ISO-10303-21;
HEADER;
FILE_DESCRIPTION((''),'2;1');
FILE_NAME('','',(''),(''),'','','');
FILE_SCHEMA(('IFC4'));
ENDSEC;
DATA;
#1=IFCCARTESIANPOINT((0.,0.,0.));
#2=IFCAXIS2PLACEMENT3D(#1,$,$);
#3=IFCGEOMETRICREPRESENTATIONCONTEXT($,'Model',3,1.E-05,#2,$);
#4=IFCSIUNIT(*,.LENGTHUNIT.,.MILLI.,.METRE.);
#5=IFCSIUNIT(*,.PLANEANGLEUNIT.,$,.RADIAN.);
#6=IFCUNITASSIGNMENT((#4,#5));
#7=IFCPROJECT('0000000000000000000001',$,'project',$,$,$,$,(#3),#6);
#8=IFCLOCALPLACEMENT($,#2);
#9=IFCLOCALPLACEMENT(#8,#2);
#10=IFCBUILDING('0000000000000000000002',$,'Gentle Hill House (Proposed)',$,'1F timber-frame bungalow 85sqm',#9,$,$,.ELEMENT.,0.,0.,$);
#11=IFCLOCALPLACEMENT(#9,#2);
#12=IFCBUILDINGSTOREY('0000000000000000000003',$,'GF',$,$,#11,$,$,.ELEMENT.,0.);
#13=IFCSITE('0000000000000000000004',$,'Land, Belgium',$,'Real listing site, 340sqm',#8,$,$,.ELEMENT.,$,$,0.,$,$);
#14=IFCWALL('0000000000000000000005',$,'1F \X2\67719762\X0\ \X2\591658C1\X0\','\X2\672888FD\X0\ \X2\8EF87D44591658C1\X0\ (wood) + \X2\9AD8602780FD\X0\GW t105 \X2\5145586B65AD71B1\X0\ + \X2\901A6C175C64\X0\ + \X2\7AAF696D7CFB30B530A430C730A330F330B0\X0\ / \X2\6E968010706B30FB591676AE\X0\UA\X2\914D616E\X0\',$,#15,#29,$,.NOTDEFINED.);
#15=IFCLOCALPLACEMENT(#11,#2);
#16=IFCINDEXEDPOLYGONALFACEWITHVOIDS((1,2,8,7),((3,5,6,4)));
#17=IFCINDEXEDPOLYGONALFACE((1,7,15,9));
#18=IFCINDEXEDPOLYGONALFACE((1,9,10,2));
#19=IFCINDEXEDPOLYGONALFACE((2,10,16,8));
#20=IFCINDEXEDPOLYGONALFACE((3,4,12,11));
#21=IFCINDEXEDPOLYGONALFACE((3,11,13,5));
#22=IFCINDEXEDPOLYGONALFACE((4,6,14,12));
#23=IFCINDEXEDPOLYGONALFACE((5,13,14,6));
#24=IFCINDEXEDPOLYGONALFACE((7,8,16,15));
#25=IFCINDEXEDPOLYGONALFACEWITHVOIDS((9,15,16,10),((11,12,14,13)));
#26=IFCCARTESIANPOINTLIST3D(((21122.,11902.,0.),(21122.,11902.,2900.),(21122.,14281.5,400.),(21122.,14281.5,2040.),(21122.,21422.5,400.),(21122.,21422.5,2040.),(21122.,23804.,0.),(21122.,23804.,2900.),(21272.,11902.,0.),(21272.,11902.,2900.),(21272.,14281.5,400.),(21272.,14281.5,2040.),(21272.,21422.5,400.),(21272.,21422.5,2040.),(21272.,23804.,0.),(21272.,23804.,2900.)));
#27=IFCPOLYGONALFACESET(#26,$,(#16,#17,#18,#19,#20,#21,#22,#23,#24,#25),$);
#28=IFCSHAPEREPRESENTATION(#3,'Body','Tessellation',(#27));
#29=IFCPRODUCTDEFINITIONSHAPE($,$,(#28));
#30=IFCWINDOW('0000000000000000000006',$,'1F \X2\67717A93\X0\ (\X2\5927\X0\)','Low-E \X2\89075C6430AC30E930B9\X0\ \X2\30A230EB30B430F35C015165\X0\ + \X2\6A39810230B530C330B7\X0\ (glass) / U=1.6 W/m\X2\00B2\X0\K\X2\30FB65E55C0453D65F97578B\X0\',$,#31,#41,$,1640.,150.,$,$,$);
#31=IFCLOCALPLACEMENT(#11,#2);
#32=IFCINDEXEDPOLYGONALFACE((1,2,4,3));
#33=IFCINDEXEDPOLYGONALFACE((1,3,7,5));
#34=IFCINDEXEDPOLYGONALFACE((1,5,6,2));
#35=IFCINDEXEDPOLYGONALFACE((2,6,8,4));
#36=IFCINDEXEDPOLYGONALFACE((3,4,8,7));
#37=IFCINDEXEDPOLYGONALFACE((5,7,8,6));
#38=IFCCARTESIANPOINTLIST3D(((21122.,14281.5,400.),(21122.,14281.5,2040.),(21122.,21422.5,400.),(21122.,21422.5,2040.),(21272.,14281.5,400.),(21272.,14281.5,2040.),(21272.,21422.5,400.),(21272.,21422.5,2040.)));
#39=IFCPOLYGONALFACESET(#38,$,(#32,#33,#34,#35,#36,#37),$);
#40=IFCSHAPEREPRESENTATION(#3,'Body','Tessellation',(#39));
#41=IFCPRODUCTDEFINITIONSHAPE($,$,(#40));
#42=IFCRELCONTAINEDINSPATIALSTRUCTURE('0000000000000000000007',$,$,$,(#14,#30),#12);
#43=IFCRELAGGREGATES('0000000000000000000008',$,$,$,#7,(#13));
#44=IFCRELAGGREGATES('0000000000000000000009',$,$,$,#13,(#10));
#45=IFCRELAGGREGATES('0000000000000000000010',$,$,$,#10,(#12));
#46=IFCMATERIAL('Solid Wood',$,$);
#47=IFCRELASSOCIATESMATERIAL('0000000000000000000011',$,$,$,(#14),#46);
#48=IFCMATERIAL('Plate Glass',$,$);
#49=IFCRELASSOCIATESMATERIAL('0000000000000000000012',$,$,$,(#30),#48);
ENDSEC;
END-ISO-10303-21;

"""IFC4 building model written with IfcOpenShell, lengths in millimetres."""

from ifc_helpers import new_model, si_unit, frame, frame_2d, origin, place, context, project, spatial, rectangle, extrude, material, element, fill, save


model = new_model("IFC4")

# Units and contexts
model_context = context("Model", 3, precision=1e-05, world=origin())
ifc_project = project(units=[si_unit("LENGTHUNIT", "METRE", prefix="MILLI"), si_unit("PLANEANGLEUNIT", "RADIAN")], contexts=[model_context])

# Site, building, storey
site_placement = place(None, origin())
site = spatial("IfcSite", under=ifc_project, at=site_placement, Name="Land, Belgium", ObjectType="Real listing site, 340sqm", CompositionType="ELEMENT", RefElevation=0.0)
building_placement = place(site_placement, origin())
building = spatial("IfcBuilding", under=site, at=building_placement, Name="Gentle Hill House (Proposed)", ObjectType="1F timber-frame bungalow 85sqm", CompositionType="ELEMENT", ElevationOfRefHeight=0.0, ElevationOfTerrain=0.0)
storey_placement = place(building_placement, origin())
storey = spatial("IfcBuildingStorey", under=building, at=storey_placement, Name="GF", CompositionType="ELEMENT", Elevation=0.0)

# Shared definitions
ifc_material_1 = material(Name="Solid Wood")

# Shared definitions
ifc_material_2 = material(Name="Plate Glass")

# Wall, opening, window
wall_1_placement = place(storey_placement, frame((10561.0, 5951.0, 0.0)))
wall_1 = element("IfcWall", 1, at=wall_1_placement, inside=storey, material=ifc_material_1, Name="1F 東面 外壁", Description="木製 軸組外壁 (wood) + 高性能GW t105 充填断熱 + 通気層 + 窯業系サイディング / 準耐火・外皮UA配慮", PredefinedType="NOTDEFINED", context=model_context, shape_type="SweptSolid", body=[
    extrude(rectangle(XDim=150.0, YDim=11902.0, at=frame_2d((75.0, 5951.0))), frame((10561.0, 5951.0, 0.0)), (0.0, 0.0, 1.0), 2900.0),
])
opening_1_placement = place(storey_placement, frame((10561.0, 7141.0, 200.0)))
opening_1 = element("IfcOpeningElement", 2, at=opening_1_placement, cuts=wall_1, PredefinedType="NOTDEFINED", context=model_context, shape_type="SweptSolid", body=[
    extrude(rectangle(XDim=150.0, YDim=7141.0, at=frame_2d((75.0, 3570.0))), frame((10561.0, 7141.0, 200.0)), (0.0, 0.0, 1.0), 1640.0),
])
window_1_placement = place(storey_placement, frame((10561.0, 7141.0, 200.0)))
window_1 = element("IfcWindow", 3, at=window_1_placement, inside=storey, material=ifc_material_2, Name="1F 東窓 (大)", Description="Low-E 複層ガラス アルゴン封入 + 樹脂サッシ (glass) / U=1.6 W/m²K・日射取得型", OverallHeight=1640.0, OverallWidth=150.0, context=model_context, shape_type="SweptSolid", body=[
    extrude(rectangle(XDim=150.0, YDim=7141.0, at=frame_2d((75.0, 3570.0))), frame((10561.0, 7141.0, 200.0)), (0.0, 0.0, 1.0), 1640.0),
])
fill(opening_1, window_1)

save(model, "model.ifc")
